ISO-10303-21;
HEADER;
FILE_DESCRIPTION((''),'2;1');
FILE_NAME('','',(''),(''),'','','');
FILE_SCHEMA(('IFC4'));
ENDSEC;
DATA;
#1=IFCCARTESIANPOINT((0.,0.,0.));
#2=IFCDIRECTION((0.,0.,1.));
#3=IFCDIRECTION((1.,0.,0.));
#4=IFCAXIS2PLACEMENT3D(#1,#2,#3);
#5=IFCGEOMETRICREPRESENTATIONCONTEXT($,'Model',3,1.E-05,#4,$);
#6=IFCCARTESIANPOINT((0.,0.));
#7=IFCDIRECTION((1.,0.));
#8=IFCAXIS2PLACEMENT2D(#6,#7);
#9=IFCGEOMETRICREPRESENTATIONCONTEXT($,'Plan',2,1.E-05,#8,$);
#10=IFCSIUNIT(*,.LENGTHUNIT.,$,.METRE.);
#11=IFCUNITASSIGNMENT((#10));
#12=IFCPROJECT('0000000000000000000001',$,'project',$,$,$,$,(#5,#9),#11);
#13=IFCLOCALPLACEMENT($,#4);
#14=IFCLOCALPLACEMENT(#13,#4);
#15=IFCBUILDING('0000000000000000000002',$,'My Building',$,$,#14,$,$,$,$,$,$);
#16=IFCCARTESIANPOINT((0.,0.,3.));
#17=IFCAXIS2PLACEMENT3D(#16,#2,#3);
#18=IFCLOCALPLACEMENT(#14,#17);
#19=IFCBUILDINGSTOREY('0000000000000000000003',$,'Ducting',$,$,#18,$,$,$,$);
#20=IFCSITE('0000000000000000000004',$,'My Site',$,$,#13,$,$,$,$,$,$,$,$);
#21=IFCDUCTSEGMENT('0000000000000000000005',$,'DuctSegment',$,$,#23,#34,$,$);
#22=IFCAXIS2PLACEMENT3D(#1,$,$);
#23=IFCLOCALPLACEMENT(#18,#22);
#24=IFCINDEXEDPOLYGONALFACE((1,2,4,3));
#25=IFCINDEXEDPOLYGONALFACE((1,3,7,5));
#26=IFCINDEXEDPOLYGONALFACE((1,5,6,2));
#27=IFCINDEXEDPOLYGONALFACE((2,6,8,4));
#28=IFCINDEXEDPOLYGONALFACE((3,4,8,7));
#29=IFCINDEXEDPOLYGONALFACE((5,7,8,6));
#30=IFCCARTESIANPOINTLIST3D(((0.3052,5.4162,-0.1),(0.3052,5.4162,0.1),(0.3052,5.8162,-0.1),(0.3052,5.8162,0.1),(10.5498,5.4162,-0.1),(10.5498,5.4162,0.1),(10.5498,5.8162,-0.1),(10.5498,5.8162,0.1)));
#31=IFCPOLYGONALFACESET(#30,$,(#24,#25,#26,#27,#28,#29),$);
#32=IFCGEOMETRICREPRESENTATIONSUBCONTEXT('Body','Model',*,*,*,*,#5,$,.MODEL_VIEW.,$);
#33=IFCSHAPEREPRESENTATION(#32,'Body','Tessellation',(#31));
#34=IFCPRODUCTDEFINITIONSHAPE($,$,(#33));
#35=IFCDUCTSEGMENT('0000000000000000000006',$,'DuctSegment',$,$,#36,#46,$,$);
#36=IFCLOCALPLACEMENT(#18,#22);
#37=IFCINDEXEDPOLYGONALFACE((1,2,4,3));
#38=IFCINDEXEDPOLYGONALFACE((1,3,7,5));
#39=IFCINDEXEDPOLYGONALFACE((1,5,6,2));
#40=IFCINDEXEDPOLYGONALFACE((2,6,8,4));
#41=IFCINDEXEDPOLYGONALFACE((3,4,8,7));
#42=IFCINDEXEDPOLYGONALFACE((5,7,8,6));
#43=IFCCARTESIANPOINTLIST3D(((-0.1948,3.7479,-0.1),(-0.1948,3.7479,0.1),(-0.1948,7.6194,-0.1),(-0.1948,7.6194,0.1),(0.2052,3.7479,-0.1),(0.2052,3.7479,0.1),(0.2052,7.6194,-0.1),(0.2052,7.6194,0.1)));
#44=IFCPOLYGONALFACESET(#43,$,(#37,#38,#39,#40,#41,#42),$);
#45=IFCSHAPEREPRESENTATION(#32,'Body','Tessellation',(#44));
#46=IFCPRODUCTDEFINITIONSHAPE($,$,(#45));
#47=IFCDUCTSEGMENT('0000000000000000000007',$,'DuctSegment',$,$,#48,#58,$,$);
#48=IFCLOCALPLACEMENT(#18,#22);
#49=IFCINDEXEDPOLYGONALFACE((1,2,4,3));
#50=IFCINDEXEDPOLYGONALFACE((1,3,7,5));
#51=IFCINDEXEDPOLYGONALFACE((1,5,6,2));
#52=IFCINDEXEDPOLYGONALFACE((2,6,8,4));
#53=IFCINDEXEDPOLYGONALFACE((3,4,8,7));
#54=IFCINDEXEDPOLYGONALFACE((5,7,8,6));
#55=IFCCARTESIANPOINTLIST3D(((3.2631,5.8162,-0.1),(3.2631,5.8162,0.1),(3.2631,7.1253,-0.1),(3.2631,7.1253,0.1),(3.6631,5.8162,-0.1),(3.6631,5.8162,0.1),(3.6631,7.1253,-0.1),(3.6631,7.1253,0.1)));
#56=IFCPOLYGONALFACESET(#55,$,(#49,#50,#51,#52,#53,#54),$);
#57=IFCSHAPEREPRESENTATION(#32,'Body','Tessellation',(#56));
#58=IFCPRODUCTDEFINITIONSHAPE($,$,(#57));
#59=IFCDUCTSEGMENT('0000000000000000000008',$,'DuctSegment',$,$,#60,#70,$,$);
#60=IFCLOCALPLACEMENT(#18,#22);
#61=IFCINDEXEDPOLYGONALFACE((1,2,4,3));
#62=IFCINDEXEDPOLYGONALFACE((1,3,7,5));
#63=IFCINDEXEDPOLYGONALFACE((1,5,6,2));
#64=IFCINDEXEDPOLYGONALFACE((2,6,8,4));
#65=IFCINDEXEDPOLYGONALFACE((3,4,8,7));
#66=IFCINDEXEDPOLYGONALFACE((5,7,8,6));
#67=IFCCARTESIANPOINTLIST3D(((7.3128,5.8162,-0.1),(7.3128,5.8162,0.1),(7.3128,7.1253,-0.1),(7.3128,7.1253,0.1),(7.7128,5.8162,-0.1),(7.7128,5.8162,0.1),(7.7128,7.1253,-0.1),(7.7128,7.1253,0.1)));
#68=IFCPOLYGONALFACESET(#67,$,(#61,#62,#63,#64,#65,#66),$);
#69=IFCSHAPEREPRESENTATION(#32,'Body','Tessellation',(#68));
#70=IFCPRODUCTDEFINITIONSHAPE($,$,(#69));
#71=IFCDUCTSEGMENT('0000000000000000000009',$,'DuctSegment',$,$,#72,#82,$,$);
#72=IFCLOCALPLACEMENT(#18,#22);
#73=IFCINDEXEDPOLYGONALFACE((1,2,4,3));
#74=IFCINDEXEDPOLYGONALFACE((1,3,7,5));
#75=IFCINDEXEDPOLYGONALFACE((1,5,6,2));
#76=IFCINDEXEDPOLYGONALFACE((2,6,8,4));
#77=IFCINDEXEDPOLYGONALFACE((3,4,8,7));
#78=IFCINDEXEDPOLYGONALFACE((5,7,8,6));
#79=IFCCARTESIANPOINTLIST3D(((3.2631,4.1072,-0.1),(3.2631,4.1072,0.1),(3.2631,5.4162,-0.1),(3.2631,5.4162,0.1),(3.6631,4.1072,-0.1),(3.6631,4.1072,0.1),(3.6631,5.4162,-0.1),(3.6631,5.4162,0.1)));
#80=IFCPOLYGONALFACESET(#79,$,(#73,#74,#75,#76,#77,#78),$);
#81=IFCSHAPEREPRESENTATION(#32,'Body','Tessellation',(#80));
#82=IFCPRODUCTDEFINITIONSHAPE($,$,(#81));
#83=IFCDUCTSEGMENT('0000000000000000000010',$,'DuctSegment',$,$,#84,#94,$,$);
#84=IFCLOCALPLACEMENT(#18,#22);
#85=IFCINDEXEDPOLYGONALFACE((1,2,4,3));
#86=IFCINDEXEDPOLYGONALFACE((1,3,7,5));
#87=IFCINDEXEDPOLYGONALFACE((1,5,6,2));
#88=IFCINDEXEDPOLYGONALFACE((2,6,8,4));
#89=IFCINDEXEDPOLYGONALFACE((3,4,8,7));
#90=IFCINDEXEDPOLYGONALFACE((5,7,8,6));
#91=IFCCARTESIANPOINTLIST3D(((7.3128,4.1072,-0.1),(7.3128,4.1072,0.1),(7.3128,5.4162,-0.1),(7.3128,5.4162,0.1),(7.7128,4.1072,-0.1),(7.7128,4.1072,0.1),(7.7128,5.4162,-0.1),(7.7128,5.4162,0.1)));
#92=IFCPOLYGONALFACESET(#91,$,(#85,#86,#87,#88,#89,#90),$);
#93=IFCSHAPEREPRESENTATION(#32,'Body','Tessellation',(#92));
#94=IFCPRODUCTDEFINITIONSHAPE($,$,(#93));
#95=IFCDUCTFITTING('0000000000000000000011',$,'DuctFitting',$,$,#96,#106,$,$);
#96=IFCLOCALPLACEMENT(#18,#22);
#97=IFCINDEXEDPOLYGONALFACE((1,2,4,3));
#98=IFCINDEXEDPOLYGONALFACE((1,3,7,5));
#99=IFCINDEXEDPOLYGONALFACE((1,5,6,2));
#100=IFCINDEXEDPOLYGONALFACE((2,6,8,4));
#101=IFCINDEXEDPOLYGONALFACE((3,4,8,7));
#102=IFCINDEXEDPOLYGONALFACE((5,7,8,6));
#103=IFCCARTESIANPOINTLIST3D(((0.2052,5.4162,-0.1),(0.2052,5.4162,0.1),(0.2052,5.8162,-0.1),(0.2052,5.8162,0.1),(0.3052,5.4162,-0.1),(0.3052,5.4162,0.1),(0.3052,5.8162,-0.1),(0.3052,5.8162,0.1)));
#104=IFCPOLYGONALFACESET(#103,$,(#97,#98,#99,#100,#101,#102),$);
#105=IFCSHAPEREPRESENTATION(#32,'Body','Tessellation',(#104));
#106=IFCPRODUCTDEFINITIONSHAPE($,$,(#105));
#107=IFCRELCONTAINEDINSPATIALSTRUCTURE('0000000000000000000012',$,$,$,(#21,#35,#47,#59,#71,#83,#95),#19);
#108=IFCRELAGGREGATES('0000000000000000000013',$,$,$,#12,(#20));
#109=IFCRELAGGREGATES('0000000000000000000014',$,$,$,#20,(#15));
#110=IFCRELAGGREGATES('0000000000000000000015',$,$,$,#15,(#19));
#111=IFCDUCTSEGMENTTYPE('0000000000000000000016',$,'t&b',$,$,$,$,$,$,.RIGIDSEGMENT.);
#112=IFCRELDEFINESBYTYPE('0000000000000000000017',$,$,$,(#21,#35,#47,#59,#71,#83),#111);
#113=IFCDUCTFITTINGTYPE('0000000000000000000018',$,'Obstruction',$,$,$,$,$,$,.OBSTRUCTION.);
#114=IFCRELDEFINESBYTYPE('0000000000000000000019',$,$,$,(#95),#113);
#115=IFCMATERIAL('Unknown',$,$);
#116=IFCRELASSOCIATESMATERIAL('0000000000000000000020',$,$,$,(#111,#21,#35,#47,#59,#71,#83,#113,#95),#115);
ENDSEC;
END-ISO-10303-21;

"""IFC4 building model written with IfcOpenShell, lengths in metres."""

from ifc_helpers import new_model, si_unit, frame, origin_with_axes, origin_2d_with_axis, place, context, subcontext, project, spatial, rectangle, extrude, material, material_profile, profile_set, profile_usage, type_object, element, save


model = new_model("IFC4")

# Units and contexts
model_context = context("Model", 3, precision=1e-05, world=origin_with_axes())
plan_context = context("Plan", 2, precision=1e-05, world=origin_2d_with_axis())
body_context = subcontext(model_context, "Body", "Model", "MODEL_VIEW")
ifc_project = project(units=[si_unit("LENGTHUNIT", "METRE")], contexts=[model_context, plan_context])

# Site, building, storey
site_placement = place(None, origin_with_axes())
site = spatial("IfcSite", under=ifc_project, at=site_placement, Name="My Site")
building_placement = place(site_placement, origin_with_axes())
building = spatial("IfcBuilding", under=site, at=building_placement, Name="My Building")
storey_placement = place(building_placement, frame((0.0, 0.0, 3.0), z_axis=(0.0, 0.0, 1.0), x_axis=(1.0, 0.0, 0.0)))
storey = spatial("IfcBuildingStorey", under=building, at=storey_placement, Name="Ducting")

# Duct segments
ifc_material = material(Name="Unknown")
ifc_material_profile_1 = material_profile(ifc_material, rectangle(XDim=0.4, YDim=0.2))
ifc_profile_set_1 = profile_set([ifc_material_profile_1])
ifc_profile_usage_1 = profile_usage(ifc_profile_set_1, cardinal=5)
duct_segment_type = type_object("IfcDuctSegmentType", Name="t&b", PredefinedType="RIGIDSEGMENT", material=ifc_profile_set_1)
duct_segment_1_placement = place(storey_placement, frame((10.5498, 5.6162, 0.0), z_axis=(-1.0, 0.0, 0.0), x_axis=(0.0, -1.0, 0.0)))
element("IfcDuctSegment", 1, at=duct_segment_1_placement, inside=storey, type_object=duct_segment_type, material=ifc_profile_usage_1, Name="DuctSegment", context=body_context, shape_type="SweptSolid", body=[
    extrude(rectangle(XDim=0.4, YDim=0.2), origin_with_axes(), (0.0, 0.0, 1.0), 10.2447),
])
ifc_profile_usage_2 = profile_usage(ifc_profile_set_1, cardinal=5)
duct_segment_2_placement = place(storey_placement, frame((0.0052, 3.7479, 0.0), z_axis=(0.0, 1.0, 0.0), x_axis=(-1.0, 0.0, 0.0)))
element("IfcDuctSegment", 2, at=duct_segment_2_placement, inside=storey, type_object=duct_segment_type, material=ifc_profile_usage_2, Name="DuctSegment", context=body_context, shape_type="SweptSolid", body=[
    extrude(rectangle(XDim=0.4, YDim=0.2), origin_with_axes(), (0.0, 0.0, 1.0), 3.8715),
])
ifc_profile_usage_3 = profile_usage(ifc_profile_set_1, cardinal=5)
duct_segment_3_placement = place(storey_placement, frame((3.4631, 5.8162, 0.0), z_axis=(0.000001, 1.0, 0.0), x_axis=(-1.0, 0.000001, 0.0)))
element("IfcDuctSegment", 3, at=duct_segment_3_placement, inside=storey, type_object=duct_segment_type, material=ifc_profile_usage_3, Name="DuctSegment", context=body_context, shape_type="SweptSolid", body=[
    extrude(rectangle(XDim=0.4, YDim=0.2), origin_with_axes(), (0.0, 0.0, 1.0), 1.309),
])
ifc_profile_usage_4 = profile_usage(ifc_profile_set_1, cardinal=5)
duct_segment_4_placement = place(storey_placement, frame((7.5128, 5.8162, 0.0), z_axis=(0.000001, 1.0, 0.0), x_axis=(-1.0, 0.000001, 0.0)))
element("IfcDuctSegment", 4, at=duct_segment_4_placement, inside=storey, type_object=duct_segment_type, material=ifc_profile_usage_4, Name="DuctSegment", context=body_context, shape_type="SweptSolid", body=[
    extrude(rectangle(XDim=0.4, YDim=0.2), origin_with_axes(), (0.0, 0.0, 1.0), 1.309),
])
ifc_profile_usage_5 = profile_usage(ifc_profile_set_1, cardinal=5)
duct_segment_5_placement = place(storey_placement, frame((3.4631, 4.1072, 0.0), z_axis=(0.000001, 1.0, 0.0), x_axis=(-1.0, 0.000001, 0.0)))
element("IfcDuctSegment", 5, at=duct_segment_5_placement, inside=storey, type_object=duct_segment_type, material=ifc_profile_usage_5, Name="DuctSegment", context=body_context, shape_type="SweptSolid", body=[
    extrude(rectangle(XDim=0.4, YDim=0.2), origin_with_axes(), (0.0, 0.0, 1.0), 1.309),
])
ifc_profile_usage_6 = profile_usage(ifc_profile_set_1, cardinal=5)
duct_segment_6_placement = place(storey_placement, frame((7.5128, 4.1072, 0.0), z_axis=(0.000001, 1.0, 0.0), x_axis=(-1.0, 0.000001, 0.0)))
element("IfcDuctSegment", 6, at=duct_segment_6_placement, inside=storey, type_object=duct_segment_type, material=ifc_profile_usage_6, Name="DuctSegment", context=body_context, shape_type="SweptSolid", body=[
    extrude(rectangle(XDim=0.4, YDim=0.2), origin_with_axes(), (0.0, 0.0, 1.0), 1.309),
])

# Duct fitting
ifc_material_profile_2 = material_profile(ifc_material, rectangle(XDim=0.4, YDim=0.2))
ifc_profile_set_2 = profile_set([ifc_material_profile_2])
ifc_profile_usage_7 = profile_usage(ifc_profile_set_2, cardinal=5)
duct_fitting_type = type_object("IfcDuctFittingType", Name="Obstruction", PredefinedType="OBSTRUCTION", material=ifc_profile_set_2)
duct_fitting_placement = place(storey_placement, frame((0.3052, 5.6162, 0.0), z_axis=(-1.0, 0.0, 0.0), x_axis=(0.0, -1.0, 0.0)))
element("IfcDuctFitting", 7, at=duct_fitting_placement, inside=storey, type_object=duct_fitting_type, material=ifc_profile_usage_7, Name="DuctFitting", context=body_context, shape_type="SweptSolid", body=[
    extrude(rectangle(XDim=0.4, YDim=0.2), origin_with_axes(), (0.0, 0.0, 1.0), 0.1),
])

save(model, "model.ifc")
